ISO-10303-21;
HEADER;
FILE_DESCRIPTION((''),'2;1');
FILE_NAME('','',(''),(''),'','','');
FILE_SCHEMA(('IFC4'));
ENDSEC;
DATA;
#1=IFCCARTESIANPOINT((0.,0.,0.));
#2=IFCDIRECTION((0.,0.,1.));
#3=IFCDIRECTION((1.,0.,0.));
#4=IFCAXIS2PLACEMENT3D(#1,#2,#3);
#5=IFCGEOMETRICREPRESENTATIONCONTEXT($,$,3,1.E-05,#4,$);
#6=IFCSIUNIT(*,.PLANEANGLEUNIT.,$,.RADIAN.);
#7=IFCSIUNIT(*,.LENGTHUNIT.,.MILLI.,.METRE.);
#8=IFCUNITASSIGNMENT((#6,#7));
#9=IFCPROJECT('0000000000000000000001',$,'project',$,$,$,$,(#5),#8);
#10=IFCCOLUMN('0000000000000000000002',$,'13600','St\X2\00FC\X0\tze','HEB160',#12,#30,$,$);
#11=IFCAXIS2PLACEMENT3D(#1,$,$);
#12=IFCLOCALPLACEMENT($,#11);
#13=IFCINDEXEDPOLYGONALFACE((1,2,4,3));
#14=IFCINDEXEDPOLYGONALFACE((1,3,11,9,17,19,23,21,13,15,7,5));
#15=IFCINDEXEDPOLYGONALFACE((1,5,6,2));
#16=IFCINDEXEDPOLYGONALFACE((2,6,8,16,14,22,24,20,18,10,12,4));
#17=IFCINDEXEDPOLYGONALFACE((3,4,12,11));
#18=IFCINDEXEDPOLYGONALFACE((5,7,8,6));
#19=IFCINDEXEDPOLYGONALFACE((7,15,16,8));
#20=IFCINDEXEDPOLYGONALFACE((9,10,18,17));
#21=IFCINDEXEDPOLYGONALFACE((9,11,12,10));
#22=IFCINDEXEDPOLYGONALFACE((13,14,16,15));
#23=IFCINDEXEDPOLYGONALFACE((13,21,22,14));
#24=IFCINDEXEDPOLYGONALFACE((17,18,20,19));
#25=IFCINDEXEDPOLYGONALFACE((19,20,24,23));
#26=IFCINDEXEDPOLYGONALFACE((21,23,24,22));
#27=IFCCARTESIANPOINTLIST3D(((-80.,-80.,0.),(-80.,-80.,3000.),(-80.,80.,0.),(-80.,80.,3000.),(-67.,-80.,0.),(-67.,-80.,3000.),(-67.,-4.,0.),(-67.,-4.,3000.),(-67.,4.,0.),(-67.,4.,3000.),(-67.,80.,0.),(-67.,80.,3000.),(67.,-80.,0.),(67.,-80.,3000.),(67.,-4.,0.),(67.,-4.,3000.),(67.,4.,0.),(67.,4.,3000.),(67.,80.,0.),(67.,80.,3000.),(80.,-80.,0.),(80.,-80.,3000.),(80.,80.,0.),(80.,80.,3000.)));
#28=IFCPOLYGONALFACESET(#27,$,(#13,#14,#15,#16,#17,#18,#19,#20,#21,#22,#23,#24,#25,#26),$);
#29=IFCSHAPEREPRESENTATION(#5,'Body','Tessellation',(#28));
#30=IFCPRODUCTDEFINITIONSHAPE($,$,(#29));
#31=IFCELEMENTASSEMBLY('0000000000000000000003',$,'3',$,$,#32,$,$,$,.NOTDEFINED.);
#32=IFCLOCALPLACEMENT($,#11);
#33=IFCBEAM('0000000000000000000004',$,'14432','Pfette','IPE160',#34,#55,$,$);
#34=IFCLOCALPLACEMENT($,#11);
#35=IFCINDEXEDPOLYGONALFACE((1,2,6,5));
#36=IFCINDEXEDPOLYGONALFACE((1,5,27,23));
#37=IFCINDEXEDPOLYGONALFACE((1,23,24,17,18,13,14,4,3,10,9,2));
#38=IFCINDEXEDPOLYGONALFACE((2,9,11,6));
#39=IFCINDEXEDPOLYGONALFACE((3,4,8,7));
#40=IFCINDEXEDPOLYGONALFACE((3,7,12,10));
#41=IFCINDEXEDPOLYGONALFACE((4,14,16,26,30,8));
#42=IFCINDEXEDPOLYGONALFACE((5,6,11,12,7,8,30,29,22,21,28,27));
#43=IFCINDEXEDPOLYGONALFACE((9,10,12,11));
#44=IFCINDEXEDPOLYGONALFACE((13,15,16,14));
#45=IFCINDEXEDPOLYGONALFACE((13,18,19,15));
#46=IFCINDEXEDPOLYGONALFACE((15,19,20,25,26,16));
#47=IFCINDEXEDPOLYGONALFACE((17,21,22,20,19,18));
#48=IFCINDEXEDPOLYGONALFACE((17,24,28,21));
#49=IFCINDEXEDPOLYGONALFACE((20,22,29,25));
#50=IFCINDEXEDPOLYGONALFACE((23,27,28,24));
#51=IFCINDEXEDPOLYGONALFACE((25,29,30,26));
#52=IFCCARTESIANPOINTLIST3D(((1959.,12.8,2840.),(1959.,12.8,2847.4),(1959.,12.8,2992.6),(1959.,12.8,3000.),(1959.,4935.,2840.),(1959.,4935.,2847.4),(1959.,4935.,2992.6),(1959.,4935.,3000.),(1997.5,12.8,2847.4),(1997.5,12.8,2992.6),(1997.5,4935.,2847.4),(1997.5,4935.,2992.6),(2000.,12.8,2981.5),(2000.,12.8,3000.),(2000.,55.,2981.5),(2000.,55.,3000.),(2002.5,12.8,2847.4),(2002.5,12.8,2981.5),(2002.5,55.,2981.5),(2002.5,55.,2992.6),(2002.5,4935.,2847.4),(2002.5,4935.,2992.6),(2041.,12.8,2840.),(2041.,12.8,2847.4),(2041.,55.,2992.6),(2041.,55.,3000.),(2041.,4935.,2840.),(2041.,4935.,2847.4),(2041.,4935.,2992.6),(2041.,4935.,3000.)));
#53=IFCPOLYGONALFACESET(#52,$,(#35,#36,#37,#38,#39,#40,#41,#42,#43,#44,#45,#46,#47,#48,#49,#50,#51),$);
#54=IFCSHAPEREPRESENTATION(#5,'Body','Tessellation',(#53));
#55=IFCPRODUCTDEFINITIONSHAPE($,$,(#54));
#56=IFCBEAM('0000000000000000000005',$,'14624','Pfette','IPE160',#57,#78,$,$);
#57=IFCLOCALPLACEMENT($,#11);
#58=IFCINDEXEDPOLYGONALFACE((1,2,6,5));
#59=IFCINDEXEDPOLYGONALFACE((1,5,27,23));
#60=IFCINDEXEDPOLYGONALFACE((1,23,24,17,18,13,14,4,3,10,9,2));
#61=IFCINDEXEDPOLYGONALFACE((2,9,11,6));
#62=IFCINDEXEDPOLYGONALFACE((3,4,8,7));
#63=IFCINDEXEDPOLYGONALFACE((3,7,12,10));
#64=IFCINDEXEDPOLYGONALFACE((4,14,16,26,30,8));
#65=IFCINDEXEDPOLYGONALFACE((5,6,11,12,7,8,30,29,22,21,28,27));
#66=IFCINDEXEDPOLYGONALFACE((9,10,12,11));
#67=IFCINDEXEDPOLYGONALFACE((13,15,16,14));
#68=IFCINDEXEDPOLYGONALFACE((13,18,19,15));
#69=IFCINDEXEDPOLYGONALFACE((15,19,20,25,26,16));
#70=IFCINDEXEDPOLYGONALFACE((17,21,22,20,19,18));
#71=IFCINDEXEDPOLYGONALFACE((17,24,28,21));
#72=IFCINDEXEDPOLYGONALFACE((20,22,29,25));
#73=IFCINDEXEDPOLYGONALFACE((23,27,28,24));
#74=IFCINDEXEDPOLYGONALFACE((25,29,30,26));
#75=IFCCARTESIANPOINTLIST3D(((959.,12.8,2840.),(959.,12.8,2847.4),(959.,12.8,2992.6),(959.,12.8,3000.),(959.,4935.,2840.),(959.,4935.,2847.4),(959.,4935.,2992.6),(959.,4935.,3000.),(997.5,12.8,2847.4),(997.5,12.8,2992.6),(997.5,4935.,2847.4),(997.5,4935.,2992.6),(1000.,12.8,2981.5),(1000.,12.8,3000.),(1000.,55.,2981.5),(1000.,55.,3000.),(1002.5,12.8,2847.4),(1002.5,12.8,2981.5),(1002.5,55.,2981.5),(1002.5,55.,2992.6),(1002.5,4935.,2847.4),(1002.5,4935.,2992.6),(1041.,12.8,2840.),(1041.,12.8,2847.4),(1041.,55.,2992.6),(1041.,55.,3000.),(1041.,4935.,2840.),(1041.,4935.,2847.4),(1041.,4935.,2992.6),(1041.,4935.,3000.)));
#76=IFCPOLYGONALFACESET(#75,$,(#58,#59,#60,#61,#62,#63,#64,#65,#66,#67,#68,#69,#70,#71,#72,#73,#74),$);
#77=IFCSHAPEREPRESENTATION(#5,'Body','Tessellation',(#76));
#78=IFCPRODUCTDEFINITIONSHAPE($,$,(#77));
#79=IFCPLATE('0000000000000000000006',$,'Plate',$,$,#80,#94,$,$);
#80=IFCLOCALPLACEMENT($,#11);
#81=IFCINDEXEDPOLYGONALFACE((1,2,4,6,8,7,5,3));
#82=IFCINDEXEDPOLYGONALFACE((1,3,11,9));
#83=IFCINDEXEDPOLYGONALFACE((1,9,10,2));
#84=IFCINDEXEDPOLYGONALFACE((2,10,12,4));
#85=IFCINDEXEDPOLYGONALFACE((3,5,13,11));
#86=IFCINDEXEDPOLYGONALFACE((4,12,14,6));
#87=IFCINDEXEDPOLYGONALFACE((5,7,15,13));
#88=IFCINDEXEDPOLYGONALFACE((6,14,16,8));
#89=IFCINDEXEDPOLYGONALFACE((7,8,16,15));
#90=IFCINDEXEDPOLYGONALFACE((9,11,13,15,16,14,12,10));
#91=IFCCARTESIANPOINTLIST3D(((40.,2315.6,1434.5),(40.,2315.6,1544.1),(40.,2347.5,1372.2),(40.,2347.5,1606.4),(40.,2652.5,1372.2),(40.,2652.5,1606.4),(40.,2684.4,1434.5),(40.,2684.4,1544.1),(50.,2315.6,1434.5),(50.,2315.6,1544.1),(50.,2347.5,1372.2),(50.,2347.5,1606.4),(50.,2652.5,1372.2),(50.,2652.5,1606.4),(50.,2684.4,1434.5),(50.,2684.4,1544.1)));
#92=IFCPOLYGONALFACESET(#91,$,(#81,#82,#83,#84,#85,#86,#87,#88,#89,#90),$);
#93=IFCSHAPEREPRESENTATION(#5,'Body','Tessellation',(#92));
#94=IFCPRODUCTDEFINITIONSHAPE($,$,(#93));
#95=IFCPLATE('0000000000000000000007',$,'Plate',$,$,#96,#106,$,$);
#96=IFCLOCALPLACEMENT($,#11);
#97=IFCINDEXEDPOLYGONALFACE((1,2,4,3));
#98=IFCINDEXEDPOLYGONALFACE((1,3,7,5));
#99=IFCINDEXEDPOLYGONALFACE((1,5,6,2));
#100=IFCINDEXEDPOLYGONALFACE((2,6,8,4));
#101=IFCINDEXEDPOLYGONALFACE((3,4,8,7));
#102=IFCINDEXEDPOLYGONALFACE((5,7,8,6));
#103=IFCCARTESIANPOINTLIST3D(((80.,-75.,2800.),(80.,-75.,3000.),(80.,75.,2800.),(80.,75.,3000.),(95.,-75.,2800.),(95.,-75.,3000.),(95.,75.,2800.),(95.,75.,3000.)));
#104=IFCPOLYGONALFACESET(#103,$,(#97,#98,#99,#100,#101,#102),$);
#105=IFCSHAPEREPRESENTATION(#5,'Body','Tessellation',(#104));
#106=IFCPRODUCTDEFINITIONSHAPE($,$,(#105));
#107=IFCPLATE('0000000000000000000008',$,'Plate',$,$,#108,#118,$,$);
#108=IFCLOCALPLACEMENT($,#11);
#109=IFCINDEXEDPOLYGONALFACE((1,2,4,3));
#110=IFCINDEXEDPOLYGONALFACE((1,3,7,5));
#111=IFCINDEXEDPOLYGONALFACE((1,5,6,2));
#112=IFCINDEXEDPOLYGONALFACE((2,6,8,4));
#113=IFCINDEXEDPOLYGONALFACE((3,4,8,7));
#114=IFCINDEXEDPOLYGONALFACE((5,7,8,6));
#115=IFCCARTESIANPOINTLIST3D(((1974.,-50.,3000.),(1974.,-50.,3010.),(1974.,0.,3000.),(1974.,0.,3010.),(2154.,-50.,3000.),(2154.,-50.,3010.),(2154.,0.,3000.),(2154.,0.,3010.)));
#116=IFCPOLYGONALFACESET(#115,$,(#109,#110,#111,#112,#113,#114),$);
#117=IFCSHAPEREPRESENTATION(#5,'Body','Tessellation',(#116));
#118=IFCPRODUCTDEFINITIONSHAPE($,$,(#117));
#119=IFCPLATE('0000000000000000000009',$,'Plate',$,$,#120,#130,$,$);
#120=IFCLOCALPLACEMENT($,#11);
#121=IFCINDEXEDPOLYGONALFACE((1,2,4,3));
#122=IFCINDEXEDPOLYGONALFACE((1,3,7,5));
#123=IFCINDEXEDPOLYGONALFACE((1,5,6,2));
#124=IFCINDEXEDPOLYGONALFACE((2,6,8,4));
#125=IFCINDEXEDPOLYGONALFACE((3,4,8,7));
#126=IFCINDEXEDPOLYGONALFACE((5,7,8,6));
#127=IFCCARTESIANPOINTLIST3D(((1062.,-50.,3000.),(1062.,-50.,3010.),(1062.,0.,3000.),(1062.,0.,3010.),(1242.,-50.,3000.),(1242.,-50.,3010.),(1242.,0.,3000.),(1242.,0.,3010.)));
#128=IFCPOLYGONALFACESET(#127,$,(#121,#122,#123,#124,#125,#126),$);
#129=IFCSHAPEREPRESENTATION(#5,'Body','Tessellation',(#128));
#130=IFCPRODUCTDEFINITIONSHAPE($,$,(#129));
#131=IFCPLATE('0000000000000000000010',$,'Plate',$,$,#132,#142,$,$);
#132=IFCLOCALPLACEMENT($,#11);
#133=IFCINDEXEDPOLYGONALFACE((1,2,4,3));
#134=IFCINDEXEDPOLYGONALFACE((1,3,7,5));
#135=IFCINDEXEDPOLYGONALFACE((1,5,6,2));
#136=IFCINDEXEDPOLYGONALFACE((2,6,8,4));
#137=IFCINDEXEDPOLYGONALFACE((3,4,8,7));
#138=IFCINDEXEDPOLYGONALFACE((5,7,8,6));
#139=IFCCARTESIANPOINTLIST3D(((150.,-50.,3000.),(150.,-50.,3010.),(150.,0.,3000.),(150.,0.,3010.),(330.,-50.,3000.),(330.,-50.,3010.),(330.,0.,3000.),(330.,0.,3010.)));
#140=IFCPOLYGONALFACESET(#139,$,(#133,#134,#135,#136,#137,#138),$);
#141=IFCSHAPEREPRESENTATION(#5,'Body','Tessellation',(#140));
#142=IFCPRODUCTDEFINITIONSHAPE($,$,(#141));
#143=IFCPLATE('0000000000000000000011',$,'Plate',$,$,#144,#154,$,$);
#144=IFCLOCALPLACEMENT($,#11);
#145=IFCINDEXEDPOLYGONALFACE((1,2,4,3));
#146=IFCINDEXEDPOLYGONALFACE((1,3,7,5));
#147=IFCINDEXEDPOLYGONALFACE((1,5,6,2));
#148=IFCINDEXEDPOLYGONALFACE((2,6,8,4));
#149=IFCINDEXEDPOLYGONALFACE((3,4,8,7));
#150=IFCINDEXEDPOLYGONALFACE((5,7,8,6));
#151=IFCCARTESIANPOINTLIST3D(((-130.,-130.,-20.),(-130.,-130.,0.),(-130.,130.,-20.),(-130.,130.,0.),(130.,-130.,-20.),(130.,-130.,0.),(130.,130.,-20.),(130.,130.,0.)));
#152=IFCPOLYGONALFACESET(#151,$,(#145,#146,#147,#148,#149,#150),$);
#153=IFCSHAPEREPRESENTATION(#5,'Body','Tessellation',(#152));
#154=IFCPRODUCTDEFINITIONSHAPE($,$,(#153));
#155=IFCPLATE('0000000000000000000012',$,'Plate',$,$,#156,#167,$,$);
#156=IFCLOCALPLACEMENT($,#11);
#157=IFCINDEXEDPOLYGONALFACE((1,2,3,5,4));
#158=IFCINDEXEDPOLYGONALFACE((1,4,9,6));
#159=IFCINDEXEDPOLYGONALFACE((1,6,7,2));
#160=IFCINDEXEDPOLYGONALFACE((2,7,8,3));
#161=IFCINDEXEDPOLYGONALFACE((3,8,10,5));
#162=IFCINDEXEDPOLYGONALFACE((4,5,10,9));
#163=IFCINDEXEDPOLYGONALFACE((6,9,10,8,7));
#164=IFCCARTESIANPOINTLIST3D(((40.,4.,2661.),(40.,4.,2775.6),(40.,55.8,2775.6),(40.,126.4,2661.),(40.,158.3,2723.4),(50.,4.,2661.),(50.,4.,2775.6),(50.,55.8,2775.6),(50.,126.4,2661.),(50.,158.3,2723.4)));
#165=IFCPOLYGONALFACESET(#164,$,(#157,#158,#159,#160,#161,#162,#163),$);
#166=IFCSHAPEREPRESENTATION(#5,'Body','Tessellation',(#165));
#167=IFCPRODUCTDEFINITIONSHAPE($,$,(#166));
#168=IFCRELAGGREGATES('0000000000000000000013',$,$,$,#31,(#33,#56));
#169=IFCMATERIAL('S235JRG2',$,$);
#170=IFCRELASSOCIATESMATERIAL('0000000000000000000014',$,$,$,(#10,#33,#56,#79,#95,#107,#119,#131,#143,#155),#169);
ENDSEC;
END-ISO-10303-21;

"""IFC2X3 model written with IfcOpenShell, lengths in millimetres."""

from ifc_helpers import new_model, si_unit, point, frame, origin_with_axes, place, context, project, polyline, line_curve, trimmed, segment, composite_curve, outline, extrude, clip, halfspace, material, element, aggregate, save


model = new_model("IFC2X3")

# Units and contexts
context_of_model = context(None, 3, precision=1e-05, world=origin_with_axes())
ifc_project = project(units=[si_unit("PLANEANGLEUNIT", "RADIAN"), si_unit("LENGTHUNIT", "METRE", prefix="MILLI")], contexts=[context_of_model])

# Column
ifc_material = material(Name="S235JRG2")
placement_1 = place(None, frame((0.0, 0.0, 3000.0), z_axis=(-1.0, 0.0, 0.0), x_axis=(0.0, 0.0, -1.0)))
column_placement = place(placement_1, origin_with_axes())
element("IfcColumn", 1, at=column_placement, material=ifc_material, Name="13600", Description="Stütze", ObjectType="HEB160", context=context_of_model, shape_type="Clipping", body=[
    clip(extrude(outline(polyline([(80.0, -80.0), (80.0, -67.0), (4.0, -67.0), (4.0, 67.0), (80.0, 67.0), (80.0, 80.0), (-80.0, 80.0), (-80.0, 67.0), (-4.0, 67.0), (-4.0, -67.0), (-80.0, -67.0), (-80.0, -80.0), (80.0, -80.0), (80.0, -80.0)])), frame((0.0, 0.0, 0.0), z_axis=(1.0, 0.0, 0.0), x_axis=(0.0, 1.0, 0.0)), (0.0, 0.0, 1.0), 3000.0), halfspace(frame((3000.0, 0.0, 0.0), z_axis=(1.0, 0.0, 0.0), x_axis=(0.0, 0.0, 1.0)), False)),
])

# Element assembly, beams, openings
assembly_1_placement = place(None, frame((1000.0, 5002.5, 6000.0), z_axis=(0.0, 0.0, 1.0), x_axis=(0.0, 1.0, 0.0)))
assembly_1 = element("IfcElementAssembly", 2, at=assembly_1_placement, Name="3", PredefinedType="NOTDEFINED")
placement_2 = place(None, frame((2000.0, 0.0, 2920.0), z_axis=(0.0, 0.0, 1.0), x_axis=(0.0, 1.0, 0.0)))
beam_1_placement = place(placement_2, origin_with_axes())
beam_1 = element("IfcBeam", 3, at=beam_1_placement, material=ifc_material, Name="14432", Description="Pfette", ObjectType="IPE160", context=context_of_model, shape_type="Clipping", body=[
    clip(clip(extrude(outline(polyline([(41.0, -80.0), (41.0, -72.6), (2.5, -72.6), (2.5, 72.6), (41.0, 72.6), (41.0, 80.0), (-41.0, 80.0), (-41.0, 72.6), (-2.5, 72.6), (-2.5, -72.6), (-41.0, -72.6), (-41.0, -80.0), (41.0, -80.0), (41.0, -80.0)])), frame((0.0, 0.0, 0.0), z_axis=(1.0, 0.0, 0.0), x_axis=(0.0, 1.0, 0.0)), (0.0, 0.0, 1.0), 4997.5), halfspace(frame((12.8, 0.0, 80.0), z_axis=(-1.0, 0.0, 0.0), x_axis=(0.0, 0.0, -1.0)), False)), halfspace(frame((4935.0, 0.0, 80.0), z_axis=(1.0, 0.0, 0.0), x_axis=(0.0, 0.0, 1.0)), False)),
])
opening_1_placement = place(beam_1_placement, frame((55.0, 0.0, 61.5), z_axis=(0.0, -1.0, 0.0), x_axis=(1.0, 0.0, 0.0)))
element("IfcOpeningElement", 4, at=opening_1_placement, cuts=beam_1, ObjectType="Recess", context=context_of_model, shape_type="SweptSolid", body=[
    extrude(outline(composite_curve([segment(trimmed(line_curve((0.0, 0.0), (0.0, 1.0, 0.0), 18.501), [point((0.0, 0.0))], [point((0.0, 18.5))], True, "CARTESIAN"), True, "CONTINUOUS"), segment(trimmed(line_curve((0.0, 18.5), (-1.0, 0.0, 0.0), 42.201), [point((0.0, 18.5))], [point((-42.2, 18.5))], True, "CARTESIAN"), True, "CONTINUOUS"), segment(trimmed(line_curve((-42.2, 18.5), (0.0, -1.0, 0.0), 18.501), [point((-42.2, 18.5))], [point((-42.2, 0.0))], True, "CARTESIAN"), True, "CONTINUOUS"), segment(trimmed(line_curve((-42.2, 0.0), (1.0, 0.0, 0.0), 42.201), [point((-42.2, 0.0))], [point((0.0, 0.0))], True, "CARTESIAN"), True, "CONTINUOUS")], self_intersect=False)), origin_with_axes(), (0.0, 0.0, 1.0), 3000.0),
])
placement_3 = place(None, frame((1000.0, 0.0, 2920.0), z_axis=(0.0, 0.0, 1.0), x_axis=(0.0, 1.0, 0.0)))
beam_2_placement = place(placement_3, origin_with_axes())
beam_2 = element("IfcBeam", 5, at=beam_2_placement, material=ifc_material, Name="14624", Description="Pfette", ObjectType="IPE160", context=context_of_model, shape_type="Clipping", body=[
    clip(clip(extrude(outline(polyline([(41.0, -80.0), (41.0, -72.6), (2.5, -72.6), (2.5, 72.6), (41.0, 72.6), (41.0, 80.0), (-41.0, 80.0), (-41.0, 72.6), (-2.5, 72.6), (-2.5, -72.6), (-41.0, -72.6), (-41.0, -80.0), (41.0, -80.0), (41.0, -80.0)])), frame((0.0, 0.0, 0.0), z_axis=(1.0, 0.0, 0.0), x_axis=(0.0, 1.0, 0.0)), (0.0, 0.0, 1.0), 4997.5), halfspace(frame((12.8, 0.0, 80.0), z_axis=(-1.0, 0.0, 0.0), x_axis=(0.0, 0.0, -1.0)), False)), halfspace(frame((4935.0, 0.0, 80.0), z_axis=(1.0, 0.0, 0.0), x_axis=(0.0, 0.0, 1.0)), False)),
])
opening_2_placement = place(beam_2_placement, frame((55.0, 0.0, 61.5), z_axis=(0.0, -1.0, 0.0), x_axis=(1.0, 0.0, 0.0)))
element("IfcOpeningElement", 6, at=opening_2_placement, cuts=beam_2, ObjectType="Recess", context=context_of_model, shape_type="SweptSolid", body=[
    extrude(outline(composite_curve([segment(trimmed(line_curve((0.0, 0.0), (0.0, 1.0, 0.0), 18.501), [point((0.0, 0.0))], [point((0.0, 18.5))], True, "CARTESIAN"), True, "CONTINUOUS"), segment(trimmed(line_curve((0.0, 18.5), (-1.0, 0.0, 0.0), 42.201), [point((0.0, 18.5))], [point((-42.2, 18.5))], True, "CARTESIAN"), True, "CONTINUOUS"), segment(trimmed(line_curve((-42.2, 18.5), (0.0, -1.0, 0.0), 18.501), [point((-42.2, 18.5))], [point((-42.2, 0.0))], True, "CARTESIAN"), True, "CONTINUOUS"), segment(trimmed(line_curve((-42.2, 0.0), (1.0, 0.0, 0.0), 42.201), [point((-42.2, 0.0))], [point((0.0, 0.0))], True, "CARTESIAN"), True, "CONTINUOUS")], self_intersect=False)), origin_with_axes(), (0.0, 0.0, 1.0), 3000.0),
])
aggregate(assembly_1, [beam_1, beam_2])

# Plates
placement_4 = place(None, frame((40.0, 2684.4, 1434.5), z_axis=(0.0, -1.0, 0.0), x_axis=(1.0, 0.0, 0.0)))
plate_1_placement = place(placement_4, origin_with_axes())
element("IfcPlate", 7, at=plate_1_placement, material=ifc_material, Name="Plate", context=context_of_model, shape_type="SweptSolid", body=[
    extrude(outline(polyline([(0.0, 0.0), (109.5, 0.0), (171.9, 31.8), (171.9, 336.9), (109.5, 368.7), (0.0, 368.7), (-62.4, 336.9), (-62.4, 31.8), (0.0, 0.0)])), frame((0.0, 0.0, 0.0), z_axis=(1.0, 0.0, 0.0), x_axis=(0.0, 1.0, 0.0)), (0.0, 0.0, 1.0), 10.0),
])
placement_5 = place(None, origin_with_axes())
plate_2_placement = place(placement_5, frame((95.0, -75.0, 2800.0), z_axis=(0.0, 1.0, 0.0), x_axis=(-1.0, 0.0, 0.0)))
element("IfcPlate", 8, at=plate_2_placement, material=ifc_material, Name="Plate", context=context_of_model, shape_type="SweptSolid", body=[
    extrude(outline(polyline([(0.0, 0.0), (200.0, 0.0), (200.0, 150.0), (0.0, 150.0), (0.0, 0.0)])), frame((0.0, 0.0, 0.0), z_axis=(1.0, 0.0, 0.0), x_axis=(0.0, 1.0, 0.0)), (0.0, 0.0, 1.0), 15.0),
])
placement_6 = place(None, origin_with_axes())
plate_3_placement = place(placement_6, frame((2154.0, -50.0, 3010.0), z_axis=(0.0, 1.0, 0.0), x_axis=(0.0, 0.0, -1.0)))
element("IfcPlate", 9, at=plate_3_placement, material=ifc_material, Name="Plate", context=context_of_model, shape_type="SweptSolid", body=[
    extrude(outline(polyline([(0.0, 0.0), (180.0, 0.0), (180.0, 50.0), (0.0, 50.0), (0.0, 0.0)])), frame((0.0, 0.0, 0.0), z_axis=(1.0, 0.0, 0.0), x_axis=(0.0, 1.0, 0.0)), (0.0, 0.0, 1.0), 10.0),
])
placement_7 = place(None, origin_with_axes())
plate_4_placement = place(placement_7, frame((1242.0, -50.0, 3010.0), z_axis=(0.0, 1.0, 0.0), x_axis=(0.0, 0.0, -1.0)))
element("IfcPlate", 10, at=plate_4_placement, material=ifc_material, Name="Plate", context=context_of_model, shape_type="SweptSolid", body=[
    extrude(outline(polyline([(0.0, 0.0), (180.0, 0.0), (180.0, 50.0), (0.0, 50.0), (0.0, 0.0)])), frame((0.0, 0.0, 0.0), z_axis=(1.0, 0.0, 0.0), x_axis=(0.0, 1.0, 0.0)), (0.0, 0.0, 1.0), 10.0),
])
placement_8 = place(None, origin_with_axes())
plate_5_placement = place(placement_8, frame((330.0, -50.0, 3010.0), z_axis=(0.0, 1.0, 0.0), x_axis=(0.0, 0.0, -1.0)))
element("IfcPlate", 11, at=plate_5_placement, material=ifc_material, Name="Plate", context=context_of_model, shape_type="SweptSolid", body=[
    extrude(outline(polyline([(0.0, 0.0), (180.0, 0.0), (180.0, 50.0), (0.0, 50.0), (0.0, 0.0)])), frame((0.0, 0.0, 0.0), z_axis=(1.0, 0.0, 0.0), x_axis=(0.0, 1.0, 0.0)), (0.0, 0.0, 1.0), 10.0),
])
placement_9 = place(None, origin_with_axes())
plate_6_placement = place(placement_9, frame((130.0, 130.0, 0.0), z_axis=(-1.0, 0.0, 0.0), x_axis=(0.0, 0.0, -1.0)))
element("IfcPlate", 12, at=plate_6_placement, material=ifc_material, Name="Plate", context=context_of_model, shape_type="SweptSolid", body=[
    extrude(outline(polyline([(0.0, 0.0), (260.0, 0.0), (260.0, 260.0), (0.0, 260.0), (0.0, 0.0)])), frame((0.0, 0.0, 0.0), z_axis=(1.0, 0.0, 0.0), x_axis=(0.0, 1.0, 0.0)), (0.0, 0.0, 1.0), 20.0),
])
placement_10 = place(None, origin_with_axes())
plate_7_placement = place(placement_10, frame((40.0, 55.8, 2775.6), z_axis=(0.0, 0.0, -1.0), x_axis=(1.0, 0.0, 0.0)))
element("IfcPlate", 13, at=plate_7_placement, material=ifc_material, Name="Plate", context=context_of_model, shape_type="SweptSolid", body=[
    extrude(outline(polyline([(0.0, 0.0), (51.8, 0.0), (51.8, 114.6), (-70.6, 114.6), (-102.4, 52.3), (0.0, 0.0)])), frame((0.0, 0.0, 0.0), z_axis=(1.0, 0.0, 0.0), x_axis=(0.0, 1.0, 0.0)), (0.0, 0.0, 1.0), 10.0),
])

save(model, "model.ifc")
